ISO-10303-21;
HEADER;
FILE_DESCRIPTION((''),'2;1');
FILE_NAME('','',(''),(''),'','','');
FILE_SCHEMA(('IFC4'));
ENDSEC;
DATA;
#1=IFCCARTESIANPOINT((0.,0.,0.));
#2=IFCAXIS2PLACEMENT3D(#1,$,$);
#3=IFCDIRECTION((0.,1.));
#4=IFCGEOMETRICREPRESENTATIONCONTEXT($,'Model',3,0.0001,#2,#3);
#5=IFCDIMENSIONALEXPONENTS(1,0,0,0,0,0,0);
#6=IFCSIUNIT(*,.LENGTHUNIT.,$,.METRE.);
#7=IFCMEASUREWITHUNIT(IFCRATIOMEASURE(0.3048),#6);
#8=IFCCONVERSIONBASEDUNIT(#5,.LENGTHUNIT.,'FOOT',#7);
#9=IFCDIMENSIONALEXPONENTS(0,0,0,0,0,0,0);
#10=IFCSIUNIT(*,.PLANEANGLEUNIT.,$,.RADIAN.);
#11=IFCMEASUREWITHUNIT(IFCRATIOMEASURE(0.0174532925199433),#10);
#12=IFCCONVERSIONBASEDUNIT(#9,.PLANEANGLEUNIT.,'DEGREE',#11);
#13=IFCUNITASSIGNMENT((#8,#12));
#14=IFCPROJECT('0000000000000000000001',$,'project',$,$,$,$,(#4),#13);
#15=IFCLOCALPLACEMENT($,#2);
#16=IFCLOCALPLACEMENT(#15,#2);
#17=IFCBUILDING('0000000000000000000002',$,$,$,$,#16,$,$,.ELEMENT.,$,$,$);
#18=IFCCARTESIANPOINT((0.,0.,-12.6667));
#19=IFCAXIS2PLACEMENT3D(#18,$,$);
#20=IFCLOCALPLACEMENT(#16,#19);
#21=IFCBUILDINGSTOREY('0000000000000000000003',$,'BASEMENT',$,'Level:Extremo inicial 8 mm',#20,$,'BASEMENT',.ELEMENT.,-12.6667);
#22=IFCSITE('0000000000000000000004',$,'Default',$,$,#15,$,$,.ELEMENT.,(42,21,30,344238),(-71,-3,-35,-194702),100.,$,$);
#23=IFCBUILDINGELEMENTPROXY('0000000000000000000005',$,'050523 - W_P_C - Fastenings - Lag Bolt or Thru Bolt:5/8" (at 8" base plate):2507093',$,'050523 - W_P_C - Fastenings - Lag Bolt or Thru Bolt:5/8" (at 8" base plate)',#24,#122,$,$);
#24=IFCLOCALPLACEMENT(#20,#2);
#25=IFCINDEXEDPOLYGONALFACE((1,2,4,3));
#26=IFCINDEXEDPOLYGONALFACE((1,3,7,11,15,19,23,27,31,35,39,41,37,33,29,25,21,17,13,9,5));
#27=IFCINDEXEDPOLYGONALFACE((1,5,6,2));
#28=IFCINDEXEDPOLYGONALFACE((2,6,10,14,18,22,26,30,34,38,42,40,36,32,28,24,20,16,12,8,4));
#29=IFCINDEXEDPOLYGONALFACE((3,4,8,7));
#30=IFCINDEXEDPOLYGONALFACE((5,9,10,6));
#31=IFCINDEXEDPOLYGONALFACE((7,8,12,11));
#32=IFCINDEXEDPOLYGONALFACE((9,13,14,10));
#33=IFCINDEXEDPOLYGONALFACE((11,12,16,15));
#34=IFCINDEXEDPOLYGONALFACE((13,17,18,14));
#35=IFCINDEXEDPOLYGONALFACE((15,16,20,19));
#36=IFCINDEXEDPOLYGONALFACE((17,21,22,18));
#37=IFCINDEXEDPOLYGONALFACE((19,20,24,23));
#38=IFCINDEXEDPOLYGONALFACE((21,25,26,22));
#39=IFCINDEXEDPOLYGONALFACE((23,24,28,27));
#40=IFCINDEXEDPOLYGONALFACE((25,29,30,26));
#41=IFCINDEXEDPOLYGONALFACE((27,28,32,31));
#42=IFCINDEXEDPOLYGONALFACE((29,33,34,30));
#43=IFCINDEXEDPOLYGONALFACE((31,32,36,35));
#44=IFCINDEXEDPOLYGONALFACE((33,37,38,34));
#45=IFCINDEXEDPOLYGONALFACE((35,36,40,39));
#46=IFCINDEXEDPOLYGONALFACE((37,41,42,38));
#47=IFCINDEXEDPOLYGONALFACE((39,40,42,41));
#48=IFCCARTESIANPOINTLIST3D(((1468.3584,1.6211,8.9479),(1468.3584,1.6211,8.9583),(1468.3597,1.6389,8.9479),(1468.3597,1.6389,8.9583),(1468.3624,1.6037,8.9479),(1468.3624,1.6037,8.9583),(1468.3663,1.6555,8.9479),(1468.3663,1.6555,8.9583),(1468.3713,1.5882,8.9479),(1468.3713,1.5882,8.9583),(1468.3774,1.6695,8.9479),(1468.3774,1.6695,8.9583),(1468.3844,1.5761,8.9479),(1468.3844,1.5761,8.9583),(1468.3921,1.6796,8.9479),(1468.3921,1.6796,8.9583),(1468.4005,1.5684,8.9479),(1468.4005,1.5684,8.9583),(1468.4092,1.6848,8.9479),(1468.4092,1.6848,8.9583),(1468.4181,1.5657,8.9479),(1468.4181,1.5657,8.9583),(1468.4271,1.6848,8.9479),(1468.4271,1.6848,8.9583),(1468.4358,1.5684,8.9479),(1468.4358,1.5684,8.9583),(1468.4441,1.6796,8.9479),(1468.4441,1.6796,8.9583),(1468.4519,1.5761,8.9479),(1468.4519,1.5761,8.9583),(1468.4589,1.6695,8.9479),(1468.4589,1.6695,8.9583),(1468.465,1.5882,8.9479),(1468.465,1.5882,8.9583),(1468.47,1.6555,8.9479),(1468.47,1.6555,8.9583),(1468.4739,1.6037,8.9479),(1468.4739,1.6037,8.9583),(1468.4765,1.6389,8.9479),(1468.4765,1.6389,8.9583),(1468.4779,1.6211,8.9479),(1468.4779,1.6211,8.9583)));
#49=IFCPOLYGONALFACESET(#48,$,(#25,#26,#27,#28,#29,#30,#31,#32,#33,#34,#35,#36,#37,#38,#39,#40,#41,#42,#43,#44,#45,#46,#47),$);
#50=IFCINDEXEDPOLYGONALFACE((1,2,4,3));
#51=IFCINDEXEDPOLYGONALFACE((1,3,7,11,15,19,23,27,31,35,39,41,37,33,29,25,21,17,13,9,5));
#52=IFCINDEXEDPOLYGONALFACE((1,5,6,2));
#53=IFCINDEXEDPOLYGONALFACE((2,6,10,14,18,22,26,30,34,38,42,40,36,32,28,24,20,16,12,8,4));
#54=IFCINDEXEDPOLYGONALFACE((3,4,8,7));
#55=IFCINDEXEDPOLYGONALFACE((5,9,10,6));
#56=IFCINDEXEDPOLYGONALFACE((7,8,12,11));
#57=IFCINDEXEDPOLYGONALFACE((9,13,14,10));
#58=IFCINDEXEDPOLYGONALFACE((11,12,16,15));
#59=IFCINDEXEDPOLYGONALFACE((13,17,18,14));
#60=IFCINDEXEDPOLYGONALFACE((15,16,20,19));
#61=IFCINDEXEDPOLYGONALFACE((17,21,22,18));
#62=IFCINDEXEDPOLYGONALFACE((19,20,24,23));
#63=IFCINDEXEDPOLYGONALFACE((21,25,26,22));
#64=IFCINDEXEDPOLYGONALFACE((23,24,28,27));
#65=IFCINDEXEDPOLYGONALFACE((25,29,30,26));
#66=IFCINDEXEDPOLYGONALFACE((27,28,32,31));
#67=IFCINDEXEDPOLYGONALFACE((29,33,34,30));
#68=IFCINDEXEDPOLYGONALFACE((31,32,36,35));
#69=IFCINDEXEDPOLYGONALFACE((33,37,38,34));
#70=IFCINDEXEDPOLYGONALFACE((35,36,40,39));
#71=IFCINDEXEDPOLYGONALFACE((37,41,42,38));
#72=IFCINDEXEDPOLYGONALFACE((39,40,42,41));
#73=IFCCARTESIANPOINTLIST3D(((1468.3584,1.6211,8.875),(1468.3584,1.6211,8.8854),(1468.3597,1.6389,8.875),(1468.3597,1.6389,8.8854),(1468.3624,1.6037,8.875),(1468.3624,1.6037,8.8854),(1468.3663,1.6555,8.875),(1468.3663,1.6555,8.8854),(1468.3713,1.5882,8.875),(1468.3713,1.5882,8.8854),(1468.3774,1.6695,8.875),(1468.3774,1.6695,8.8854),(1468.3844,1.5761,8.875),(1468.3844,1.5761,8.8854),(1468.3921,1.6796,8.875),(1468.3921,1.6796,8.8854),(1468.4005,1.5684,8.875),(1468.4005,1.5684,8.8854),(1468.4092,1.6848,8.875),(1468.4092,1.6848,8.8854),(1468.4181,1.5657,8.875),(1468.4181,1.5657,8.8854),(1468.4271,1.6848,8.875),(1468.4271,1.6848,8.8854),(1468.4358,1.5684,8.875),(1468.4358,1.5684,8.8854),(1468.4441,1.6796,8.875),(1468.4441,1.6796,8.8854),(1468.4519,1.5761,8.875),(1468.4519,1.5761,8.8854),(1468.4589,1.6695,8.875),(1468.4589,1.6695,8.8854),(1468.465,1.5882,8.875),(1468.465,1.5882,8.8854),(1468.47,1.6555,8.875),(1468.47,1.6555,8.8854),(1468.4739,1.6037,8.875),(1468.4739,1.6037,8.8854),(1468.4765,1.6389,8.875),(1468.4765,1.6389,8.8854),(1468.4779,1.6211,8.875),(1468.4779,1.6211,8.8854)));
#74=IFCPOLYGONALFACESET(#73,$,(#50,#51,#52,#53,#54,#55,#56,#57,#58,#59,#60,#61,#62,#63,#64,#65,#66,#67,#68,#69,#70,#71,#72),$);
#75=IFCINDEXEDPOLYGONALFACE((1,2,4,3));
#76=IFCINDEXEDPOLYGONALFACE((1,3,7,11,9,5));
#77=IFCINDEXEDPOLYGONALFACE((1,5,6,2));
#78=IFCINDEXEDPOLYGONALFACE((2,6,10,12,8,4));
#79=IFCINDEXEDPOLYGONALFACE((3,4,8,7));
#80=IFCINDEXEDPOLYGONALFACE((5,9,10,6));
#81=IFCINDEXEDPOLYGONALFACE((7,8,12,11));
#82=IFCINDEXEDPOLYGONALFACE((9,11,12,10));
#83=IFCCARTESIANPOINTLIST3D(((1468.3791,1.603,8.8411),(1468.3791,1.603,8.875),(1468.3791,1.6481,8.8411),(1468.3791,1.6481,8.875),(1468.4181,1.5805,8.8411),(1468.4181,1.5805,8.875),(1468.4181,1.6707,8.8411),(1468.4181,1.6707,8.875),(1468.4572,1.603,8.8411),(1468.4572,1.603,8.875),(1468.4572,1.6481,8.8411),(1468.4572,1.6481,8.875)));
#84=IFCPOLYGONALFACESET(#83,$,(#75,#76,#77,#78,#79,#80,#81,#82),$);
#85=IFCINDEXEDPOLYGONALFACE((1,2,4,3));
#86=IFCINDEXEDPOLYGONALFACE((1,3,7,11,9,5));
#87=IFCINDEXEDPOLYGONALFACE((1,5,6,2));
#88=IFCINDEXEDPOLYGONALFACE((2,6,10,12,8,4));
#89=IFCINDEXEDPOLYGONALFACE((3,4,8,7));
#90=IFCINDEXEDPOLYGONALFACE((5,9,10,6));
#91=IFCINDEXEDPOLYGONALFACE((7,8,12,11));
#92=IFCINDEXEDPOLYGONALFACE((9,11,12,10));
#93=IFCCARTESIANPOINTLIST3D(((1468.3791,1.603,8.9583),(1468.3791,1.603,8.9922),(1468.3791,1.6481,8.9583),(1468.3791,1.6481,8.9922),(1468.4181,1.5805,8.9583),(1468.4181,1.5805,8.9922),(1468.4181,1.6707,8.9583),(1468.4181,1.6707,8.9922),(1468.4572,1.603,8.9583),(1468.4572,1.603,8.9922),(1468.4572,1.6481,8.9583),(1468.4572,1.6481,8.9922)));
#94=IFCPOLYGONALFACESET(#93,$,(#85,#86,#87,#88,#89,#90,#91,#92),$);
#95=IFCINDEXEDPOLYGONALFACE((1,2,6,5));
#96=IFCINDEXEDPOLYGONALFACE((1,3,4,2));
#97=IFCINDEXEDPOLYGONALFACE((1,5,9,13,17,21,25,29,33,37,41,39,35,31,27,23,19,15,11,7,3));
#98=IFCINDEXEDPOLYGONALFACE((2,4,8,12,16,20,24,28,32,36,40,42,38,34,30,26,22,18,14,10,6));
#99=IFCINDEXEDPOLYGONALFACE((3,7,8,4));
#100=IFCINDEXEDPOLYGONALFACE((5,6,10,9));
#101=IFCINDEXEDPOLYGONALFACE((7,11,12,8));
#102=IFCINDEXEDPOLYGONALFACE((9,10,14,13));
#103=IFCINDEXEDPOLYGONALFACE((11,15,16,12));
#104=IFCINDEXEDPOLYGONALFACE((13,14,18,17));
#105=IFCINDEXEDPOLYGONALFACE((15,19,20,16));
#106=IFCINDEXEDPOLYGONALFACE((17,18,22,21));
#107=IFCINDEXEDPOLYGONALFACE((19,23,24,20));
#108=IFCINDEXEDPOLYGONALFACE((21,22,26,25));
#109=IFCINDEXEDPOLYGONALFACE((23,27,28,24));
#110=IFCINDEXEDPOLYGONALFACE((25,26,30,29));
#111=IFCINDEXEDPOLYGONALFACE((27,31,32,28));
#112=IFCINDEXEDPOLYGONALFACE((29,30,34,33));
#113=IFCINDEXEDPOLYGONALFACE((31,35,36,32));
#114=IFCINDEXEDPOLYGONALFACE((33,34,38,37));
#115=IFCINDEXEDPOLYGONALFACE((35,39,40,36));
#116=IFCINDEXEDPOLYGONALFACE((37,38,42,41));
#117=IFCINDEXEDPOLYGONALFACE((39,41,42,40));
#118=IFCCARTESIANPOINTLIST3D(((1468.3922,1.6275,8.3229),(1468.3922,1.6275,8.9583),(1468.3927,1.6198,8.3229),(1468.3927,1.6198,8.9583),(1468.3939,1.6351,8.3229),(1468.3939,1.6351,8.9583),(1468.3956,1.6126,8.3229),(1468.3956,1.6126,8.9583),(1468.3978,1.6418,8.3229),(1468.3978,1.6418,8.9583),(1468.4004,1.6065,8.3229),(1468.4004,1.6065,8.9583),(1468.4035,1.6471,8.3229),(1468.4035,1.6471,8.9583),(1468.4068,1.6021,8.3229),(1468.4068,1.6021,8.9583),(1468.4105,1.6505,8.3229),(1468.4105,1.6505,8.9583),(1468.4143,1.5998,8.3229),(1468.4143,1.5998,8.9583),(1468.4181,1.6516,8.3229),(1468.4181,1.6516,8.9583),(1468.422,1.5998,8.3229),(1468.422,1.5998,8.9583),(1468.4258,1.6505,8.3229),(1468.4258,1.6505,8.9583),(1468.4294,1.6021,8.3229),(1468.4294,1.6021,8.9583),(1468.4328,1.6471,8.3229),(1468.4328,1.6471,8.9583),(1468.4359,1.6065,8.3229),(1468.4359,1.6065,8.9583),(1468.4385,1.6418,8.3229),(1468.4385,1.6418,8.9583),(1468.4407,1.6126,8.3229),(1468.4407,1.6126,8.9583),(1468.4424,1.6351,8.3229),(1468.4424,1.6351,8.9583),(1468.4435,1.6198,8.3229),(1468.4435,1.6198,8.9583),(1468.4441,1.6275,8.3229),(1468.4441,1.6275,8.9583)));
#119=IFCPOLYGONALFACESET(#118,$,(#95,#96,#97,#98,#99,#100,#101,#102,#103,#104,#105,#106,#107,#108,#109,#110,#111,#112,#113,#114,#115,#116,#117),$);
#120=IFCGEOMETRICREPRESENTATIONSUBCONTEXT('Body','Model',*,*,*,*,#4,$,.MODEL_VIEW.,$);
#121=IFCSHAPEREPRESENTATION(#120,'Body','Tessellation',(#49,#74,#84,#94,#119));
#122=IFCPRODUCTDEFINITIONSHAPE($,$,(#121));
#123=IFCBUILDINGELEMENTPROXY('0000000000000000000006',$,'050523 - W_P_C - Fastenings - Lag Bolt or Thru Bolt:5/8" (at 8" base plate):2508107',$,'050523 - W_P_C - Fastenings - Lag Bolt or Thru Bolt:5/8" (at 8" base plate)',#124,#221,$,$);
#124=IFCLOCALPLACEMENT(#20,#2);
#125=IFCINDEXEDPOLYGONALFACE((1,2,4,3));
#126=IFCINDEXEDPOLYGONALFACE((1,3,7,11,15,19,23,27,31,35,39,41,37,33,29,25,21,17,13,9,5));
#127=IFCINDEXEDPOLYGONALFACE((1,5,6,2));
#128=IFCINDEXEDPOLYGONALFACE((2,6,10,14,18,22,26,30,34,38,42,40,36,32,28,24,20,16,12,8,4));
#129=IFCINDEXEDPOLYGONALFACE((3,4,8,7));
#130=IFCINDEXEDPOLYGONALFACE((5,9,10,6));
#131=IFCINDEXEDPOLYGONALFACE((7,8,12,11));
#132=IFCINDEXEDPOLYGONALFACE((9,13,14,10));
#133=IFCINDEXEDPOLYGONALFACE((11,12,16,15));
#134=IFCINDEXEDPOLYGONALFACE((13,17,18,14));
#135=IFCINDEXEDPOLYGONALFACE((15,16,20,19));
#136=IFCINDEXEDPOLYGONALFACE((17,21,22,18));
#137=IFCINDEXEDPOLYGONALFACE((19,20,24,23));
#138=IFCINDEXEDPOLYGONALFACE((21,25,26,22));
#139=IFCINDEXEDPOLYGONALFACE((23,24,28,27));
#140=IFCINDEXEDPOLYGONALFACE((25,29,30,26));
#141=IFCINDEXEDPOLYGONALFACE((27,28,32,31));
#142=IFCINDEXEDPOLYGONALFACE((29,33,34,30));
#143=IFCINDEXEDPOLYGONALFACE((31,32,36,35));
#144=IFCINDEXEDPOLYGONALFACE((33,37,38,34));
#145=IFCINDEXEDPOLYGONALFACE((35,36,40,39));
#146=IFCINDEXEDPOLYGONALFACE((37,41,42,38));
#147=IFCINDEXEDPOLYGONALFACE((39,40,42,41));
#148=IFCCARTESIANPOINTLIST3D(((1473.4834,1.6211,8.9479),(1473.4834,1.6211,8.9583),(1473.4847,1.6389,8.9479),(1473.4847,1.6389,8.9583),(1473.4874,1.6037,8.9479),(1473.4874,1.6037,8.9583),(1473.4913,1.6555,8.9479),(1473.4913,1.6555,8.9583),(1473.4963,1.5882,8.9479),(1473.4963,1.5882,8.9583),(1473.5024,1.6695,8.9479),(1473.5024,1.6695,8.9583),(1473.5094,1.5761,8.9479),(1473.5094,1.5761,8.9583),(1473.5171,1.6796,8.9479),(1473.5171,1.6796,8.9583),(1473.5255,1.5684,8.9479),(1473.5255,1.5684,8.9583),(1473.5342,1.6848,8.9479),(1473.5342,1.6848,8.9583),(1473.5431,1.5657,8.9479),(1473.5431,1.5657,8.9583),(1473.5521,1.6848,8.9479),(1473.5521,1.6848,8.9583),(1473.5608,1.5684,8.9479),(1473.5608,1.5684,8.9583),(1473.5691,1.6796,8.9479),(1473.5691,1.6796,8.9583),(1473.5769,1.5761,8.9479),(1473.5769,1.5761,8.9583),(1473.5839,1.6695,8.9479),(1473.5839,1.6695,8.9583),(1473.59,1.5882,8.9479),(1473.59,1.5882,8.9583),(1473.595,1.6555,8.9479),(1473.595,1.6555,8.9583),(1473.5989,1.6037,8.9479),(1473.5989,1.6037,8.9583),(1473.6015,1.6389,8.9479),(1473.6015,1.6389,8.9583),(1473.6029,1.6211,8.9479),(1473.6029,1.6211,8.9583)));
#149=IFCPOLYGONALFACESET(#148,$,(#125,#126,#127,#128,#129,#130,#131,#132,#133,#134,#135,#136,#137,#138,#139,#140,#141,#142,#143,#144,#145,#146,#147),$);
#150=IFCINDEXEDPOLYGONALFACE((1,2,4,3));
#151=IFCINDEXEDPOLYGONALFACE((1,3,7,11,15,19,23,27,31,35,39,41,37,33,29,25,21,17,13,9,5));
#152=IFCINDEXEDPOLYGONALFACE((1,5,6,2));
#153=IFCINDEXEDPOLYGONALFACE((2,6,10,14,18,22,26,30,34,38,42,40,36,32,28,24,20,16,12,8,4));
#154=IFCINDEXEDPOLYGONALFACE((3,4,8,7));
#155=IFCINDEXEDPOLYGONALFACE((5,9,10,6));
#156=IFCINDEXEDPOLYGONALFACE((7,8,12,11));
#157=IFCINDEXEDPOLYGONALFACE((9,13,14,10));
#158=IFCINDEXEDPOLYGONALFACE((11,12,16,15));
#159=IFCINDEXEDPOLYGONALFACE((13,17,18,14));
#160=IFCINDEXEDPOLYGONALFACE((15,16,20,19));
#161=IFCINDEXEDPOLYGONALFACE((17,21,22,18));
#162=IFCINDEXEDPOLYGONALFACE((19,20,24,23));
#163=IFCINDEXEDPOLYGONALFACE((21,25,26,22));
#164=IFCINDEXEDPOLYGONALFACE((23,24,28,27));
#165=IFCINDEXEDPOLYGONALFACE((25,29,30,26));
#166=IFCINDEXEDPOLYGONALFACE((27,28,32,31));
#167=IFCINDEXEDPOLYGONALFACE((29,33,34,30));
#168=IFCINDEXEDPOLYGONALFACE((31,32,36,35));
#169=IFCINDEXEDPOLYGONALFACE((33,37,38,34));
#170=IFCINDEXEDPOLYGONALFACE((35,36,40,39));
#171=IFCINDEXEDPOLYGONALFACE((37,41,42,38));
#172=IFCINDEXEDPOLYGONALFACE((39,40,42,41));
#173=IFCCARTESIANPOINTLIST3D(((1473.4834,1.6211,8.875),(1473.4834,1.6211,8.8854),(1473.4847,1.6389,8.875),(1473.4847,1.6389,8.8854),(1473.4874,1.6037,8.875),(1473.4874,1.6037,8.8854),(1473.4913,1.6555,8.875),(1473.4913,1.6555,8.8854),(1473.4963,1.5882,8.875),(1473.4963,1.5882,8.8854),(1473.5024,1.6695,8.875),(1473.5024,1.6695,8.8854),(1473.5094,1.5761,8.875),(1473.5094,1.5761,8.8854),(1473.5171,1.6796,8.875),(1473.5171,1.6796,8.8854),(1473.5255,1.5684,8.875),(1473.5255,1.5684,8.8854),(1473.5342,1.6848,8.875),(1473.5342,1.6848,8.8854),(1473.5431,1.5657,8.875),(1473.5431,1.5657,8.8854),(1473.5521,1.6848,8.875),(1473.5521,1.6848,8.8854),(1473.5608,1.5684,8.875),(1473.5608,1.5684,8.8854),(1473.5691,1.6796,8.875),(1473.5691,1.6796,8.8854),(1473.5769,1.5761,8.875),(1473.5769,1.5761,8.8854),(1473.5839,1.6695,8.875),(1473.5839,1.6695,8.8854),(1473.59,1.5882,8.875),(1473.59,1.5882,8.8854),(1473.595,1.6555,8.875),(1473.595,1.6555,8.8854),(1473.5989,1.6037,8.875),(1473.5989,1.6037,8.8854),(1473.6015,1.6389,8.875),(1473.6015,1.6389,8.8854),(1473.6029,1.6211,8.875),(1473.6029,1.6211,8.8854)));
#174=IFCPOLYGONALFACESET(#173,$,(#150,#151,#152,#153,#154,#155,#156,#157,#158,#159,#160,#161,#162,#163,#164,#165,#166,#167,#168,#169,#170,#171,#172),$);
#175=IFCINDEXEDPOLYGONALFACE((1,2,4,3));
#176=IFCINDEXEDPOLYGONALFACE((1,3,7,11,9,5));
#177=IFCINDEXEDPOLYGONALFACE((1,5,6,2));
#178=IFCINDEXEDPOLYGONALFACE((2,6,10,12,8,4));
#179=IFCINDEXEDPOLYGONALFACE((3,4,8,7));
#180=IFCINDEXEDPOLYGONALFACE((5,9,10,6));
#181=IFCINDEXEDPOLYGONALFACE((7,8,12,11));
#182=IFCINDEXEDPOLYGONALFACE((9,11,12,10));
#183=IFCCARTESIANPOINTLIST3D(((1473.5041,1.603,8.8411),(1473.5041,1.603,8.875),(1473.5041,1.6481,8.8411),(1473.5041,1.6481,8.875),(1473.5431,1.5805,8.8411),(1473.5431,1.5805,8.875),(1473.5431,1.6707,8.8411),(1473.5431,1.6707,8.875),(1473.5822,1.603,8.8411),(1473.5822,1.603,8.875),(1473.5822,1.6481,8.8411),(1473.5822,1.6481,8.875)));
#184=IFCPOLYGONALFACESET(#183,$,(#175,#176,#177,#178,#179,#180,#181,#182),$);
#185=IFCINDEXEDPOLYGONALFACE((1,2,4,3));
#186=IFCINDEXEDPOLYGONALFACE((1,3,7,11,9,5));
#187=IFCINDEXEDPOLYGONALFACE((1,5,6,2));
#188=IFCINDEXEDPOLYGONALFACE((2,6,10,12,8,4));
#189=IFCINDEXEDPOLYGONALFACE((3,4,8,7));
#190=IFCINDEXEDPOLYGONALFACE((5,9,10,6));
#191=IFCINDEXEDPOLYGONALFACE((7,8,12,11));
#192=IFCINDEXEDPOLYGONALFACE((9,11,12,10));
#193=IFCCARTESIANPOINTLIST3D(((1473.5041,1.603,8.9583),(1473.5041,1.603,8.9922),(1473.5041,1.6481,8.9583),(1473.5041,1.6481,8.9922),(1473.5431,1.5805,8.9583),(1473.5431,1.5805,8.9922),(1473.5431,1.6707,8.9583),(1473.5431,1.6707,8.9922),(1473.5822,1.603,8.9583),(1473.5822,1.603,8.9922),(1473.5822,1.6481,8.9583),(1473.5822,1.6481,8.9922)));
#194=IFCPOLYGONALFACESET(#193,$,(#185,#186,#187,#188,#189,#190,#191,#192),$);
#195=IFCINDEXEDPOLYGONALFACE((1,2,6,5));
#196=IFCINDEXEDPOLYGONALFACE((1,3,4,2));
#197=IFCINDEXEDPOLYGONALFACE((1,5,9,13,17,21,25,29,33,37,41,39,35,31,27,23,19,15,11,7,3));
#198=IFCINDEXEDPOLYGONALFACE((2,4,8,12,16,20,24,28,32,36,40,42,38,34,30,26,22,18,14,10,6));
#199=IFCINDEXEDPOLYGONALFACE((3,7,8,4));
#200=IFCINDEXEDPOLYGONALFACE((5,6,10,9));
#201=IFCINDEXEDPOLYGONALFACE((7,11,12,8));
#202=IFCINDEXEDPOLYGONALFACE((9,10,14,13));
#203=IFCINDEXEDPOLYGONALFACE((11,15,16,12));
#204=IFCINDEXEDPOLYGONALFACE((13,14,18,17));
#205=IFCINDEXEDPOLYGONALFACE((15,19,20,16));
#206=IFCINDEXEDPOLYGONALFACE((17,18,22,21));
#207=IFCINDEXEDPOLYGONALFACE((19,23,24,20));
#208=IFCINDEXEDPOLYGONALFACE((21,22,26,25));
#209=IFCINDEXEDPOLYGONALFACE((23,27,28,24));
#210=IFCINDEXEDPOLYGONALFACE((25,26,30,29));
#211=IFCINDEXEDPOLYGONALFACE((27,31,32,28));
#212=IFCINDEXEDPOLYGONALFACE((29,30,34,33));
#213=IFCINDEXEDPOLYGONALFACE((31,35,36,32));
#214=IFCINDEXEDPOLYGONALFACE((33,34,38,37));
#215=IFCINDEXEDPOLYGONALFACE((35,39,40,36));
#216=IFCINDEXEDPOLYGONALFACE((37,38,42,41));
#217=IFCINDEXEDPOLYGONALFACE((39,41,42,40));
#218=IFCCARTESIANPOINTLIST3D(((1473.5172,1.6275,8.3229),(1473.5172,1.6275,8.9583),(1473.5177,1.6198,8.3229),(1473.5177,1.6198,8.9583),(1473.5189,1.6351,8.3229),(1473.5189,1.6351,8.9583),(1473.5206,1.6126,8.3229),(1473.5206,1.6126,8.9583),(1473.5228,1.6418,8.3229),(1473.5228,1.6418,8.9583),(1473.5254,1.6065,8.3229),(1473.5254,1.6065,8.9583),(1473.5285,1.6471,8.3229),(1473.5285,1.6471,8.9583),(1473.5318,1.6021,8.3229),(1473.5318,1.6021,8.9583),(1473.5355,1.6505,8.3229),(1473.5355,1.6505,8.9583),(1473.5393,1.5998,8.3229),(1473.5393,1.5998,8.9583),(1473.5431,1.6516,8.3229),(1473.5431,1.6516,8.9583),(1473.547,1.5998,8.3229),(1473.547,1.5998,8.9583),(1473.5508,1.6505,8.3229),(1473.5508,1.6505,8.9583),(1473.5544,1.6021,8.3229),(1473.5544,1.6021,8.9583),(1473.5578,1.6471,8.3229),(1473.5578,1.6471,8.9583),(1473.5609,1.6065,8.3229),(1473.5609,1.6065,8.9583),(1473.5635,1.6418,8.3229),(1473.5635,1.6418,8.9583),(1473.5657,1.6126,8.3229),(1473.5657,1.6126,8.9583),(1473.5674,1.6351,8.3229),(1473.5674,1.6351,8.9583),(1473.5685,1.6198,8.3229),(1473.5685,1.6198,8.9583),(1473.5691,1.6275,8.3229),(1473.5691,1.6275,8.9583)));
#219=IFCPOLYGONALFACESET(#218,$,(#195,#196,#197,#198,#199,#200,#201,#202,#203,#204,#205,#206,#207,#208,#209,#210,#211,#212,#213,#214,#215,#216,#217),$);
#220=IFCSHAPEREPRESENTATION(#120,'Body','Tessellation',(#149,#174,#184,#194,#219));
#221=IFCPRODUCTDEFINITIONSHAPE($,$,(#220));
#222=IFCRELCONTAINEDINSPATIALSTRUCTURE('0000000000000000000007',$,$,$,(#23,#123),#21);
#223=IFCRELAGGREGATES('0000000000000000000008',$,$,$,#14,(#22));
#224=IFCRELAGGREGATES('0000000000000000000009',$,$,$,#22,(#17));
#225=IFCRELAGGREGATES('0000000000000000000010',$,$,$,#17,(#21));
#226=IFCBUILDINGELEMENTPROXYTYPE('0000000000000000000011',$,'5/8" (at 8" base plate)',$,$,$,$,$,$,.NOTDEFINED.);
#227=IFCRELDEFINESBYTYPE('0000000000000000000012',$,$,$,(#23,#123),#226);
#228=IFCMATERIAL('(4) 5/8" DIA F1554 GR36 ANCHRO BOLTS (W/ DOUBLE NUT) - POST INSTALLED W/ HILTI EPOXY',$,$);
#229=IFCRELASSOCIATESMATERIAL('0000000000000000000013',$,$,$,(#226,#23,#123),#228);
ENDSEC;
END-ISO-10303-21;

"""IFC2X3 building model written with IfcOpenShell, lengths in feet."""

from ifc_helpers import new_model, entity, si_unit, converted_unit, direction, frame, frame_2d, origin, place, context, subcontext, project, spatial, polyline, circle, outline, extrude, source, transform, mapped, material, type_object, type_shapes, element, save


model = new_model("IFC2X3")

# Units and contexts
model_context = context("Model", 3, precision=0.0001, world=origin(), true_north=direction((0.0, 1.0)))
body_context = subcontext(model_context, "Body", "Model", "MODEL_VIEW")
ifc_project = project(units=[converted_unit("LENGTHUNIT", "FOOT", entity("IfcRatioMeasure", 0.3048), si_unit("LENGTHUNIT", "METRE"), dimensions=[1, 0, 0, 0, 0, 0, 0]), converted_unit("PLANEANGLEUNIT", "DEGREE", entity("IfcRatioMeasure", 0.0174532925199433), si_unit("PLANEANGLEUNIT", "RADIAN"), dimensions=[0, 0, 0, 0, 0, 0, 0])], contexts=[model_context])

# Site, building, storey
site_placement = place(None, origin())
site = spatial("IfcSite", under=ifc_project, at=site_placement, Name="Default", CompositionType="ELEMENT", RefLatitude=(42, 21, 30, 344238), RefLongitude=(-71, -3, -35, -194702), RefElevation=100.0)
building_placement = place(site_placement, origin())
building = spatial("IfcBuilding", under=site, at=building_placement, CompositionType="ELEMENT")
storey_placement = place(building_placement, frame((0.0, 0.0, -12.6667)))
storey = spatial("IfcBuildingStorey", under=building, at=storey_placement, Name="BASEMENT", ObjectType="Level:Extremo inicial 8 mm", LongName="BASEMENT", CompositionType="ELEMENT", Elevation=-12.6667)

# Building element proxies
ifc_material_1 = material(Name="(4) 5/8\" DIA F1554 GR36 ANCHRO BOLTS (W/ DOUBLE NUT) - POST INSTALLED W/ HILTI EPOXY")
building_element_proxy_type_1 = type_object("IfcBuildingElementProxyType", Name="5/8\" (at 8\" base plate)", PredefinedType="NOTDEFINED", material=ifc_material_1)
shared_shape_1 = source(origin(), body_context, "Body", "SweptSolid", [
    extrude(circle(Radius=0.0599, at=frame_2d((0.0, 0.0), x_axis=(1.0, 0.0))), frame((0.0, 0.0, 0.0), z_axis=(0.0, 0.0, 1.0), x_axis=(0.0, 1.0, 0.0)), (0.0, 0.0, 1.0), 0.0104),
    extrude(circle(Radius=0.0599, at=frame_2d((0.0, 0.0), x_axis=(1.0, 0.0))), frame((0.0, 0.0, -0.0729), z_axis=(0.0, 0.0, 1.0), x_axis=(0.0, 1.0, 0.0)), (0.0, 0.0, 1.0), 0.0104),
    extrude(outline(polyline([(-0.0226, -0.0391), (0.0226, -0.0391), (0.0451, 0.0), (0.0226, 0.0391), (-0.0226, 0.0391), (-0.0451, 0.0), (-0.0226, -0.0391)])), frame((0.0, 0.0, -0.1068), z_axis=(0.0, 0.0, 1.0), x_axis=(0.0, -1.0, 0.0)), (0.0, 0.0, 1.0), 0.0339),
    extrude(outline(polyline([(-0.0226, -0.0391), (0.0226, -0.0391), (0.0451, 0.0), (0.0226, 0.0391), (-0.0226, 0.0391), (-0.0451, 0.0), (-0.0226, -0.0391)])), frame((0.0, 0.0, 0.0104), z_axis=(0.0, 0.0, 1.0), x_axis=(0.866025, -0.5, 0.0)), (0.0, 0.0, 1.0), 0.0339),
    extrude(circle(Radius=0.026, at=frame_2d((0.0, 0.0), x_axis=(1.0, 0.0))), frame((0.0, 0.0, -0.625), z_axis=(0.0, 0.0, 1.0), x_axis=(0.0, -1.0, 0.0)), (0.0, 0.0, 1.0), 0.6354),
])
type_shapes(building_element_proxy_type_1, [shared_shape_1])
for number, where, z_axis, x_axis, name in (
    (1, (1468.4181, 1.6256, 8.9479), (0.0, 0.0, 1.0), (-1.0, 0.0, 0.0), "050523 - W_P_C - Fastenings - Lag Bolt or Thru Bolt:5/8\" (at 8\" base plate):2507093"),
    (2, (1473.5431, 1.6256, 8.9479), (0.0, 0.0, 1.0), (-1.0, 0.0, 0.0), "050523 - W_P_C - Fastenings - Lag Bolt or Thru Bolt:5/8\" (at 8\" base plate):2508107"),
):
    element("IfcBuildingElementProxy", number, at=place(storey_placement, frame(where, z_axis=z_axis, x_axis=x_axis)), inside=storey, type_object=building_element_proxy_type_1, material=ifc_material_1, Name=name, ObjectType="050523 - W_P_C - Fastenings - Lag Bolt or Thru Bolt:5/8\" (at 8\" base plate)", context=body_context, shape_type="MappedRepresentation", body=[
        mapped(shared_shape_1, transform((0.0, 0.0, 0.0), scale=1.0)),
    ])

save(model, "model.ifc")
